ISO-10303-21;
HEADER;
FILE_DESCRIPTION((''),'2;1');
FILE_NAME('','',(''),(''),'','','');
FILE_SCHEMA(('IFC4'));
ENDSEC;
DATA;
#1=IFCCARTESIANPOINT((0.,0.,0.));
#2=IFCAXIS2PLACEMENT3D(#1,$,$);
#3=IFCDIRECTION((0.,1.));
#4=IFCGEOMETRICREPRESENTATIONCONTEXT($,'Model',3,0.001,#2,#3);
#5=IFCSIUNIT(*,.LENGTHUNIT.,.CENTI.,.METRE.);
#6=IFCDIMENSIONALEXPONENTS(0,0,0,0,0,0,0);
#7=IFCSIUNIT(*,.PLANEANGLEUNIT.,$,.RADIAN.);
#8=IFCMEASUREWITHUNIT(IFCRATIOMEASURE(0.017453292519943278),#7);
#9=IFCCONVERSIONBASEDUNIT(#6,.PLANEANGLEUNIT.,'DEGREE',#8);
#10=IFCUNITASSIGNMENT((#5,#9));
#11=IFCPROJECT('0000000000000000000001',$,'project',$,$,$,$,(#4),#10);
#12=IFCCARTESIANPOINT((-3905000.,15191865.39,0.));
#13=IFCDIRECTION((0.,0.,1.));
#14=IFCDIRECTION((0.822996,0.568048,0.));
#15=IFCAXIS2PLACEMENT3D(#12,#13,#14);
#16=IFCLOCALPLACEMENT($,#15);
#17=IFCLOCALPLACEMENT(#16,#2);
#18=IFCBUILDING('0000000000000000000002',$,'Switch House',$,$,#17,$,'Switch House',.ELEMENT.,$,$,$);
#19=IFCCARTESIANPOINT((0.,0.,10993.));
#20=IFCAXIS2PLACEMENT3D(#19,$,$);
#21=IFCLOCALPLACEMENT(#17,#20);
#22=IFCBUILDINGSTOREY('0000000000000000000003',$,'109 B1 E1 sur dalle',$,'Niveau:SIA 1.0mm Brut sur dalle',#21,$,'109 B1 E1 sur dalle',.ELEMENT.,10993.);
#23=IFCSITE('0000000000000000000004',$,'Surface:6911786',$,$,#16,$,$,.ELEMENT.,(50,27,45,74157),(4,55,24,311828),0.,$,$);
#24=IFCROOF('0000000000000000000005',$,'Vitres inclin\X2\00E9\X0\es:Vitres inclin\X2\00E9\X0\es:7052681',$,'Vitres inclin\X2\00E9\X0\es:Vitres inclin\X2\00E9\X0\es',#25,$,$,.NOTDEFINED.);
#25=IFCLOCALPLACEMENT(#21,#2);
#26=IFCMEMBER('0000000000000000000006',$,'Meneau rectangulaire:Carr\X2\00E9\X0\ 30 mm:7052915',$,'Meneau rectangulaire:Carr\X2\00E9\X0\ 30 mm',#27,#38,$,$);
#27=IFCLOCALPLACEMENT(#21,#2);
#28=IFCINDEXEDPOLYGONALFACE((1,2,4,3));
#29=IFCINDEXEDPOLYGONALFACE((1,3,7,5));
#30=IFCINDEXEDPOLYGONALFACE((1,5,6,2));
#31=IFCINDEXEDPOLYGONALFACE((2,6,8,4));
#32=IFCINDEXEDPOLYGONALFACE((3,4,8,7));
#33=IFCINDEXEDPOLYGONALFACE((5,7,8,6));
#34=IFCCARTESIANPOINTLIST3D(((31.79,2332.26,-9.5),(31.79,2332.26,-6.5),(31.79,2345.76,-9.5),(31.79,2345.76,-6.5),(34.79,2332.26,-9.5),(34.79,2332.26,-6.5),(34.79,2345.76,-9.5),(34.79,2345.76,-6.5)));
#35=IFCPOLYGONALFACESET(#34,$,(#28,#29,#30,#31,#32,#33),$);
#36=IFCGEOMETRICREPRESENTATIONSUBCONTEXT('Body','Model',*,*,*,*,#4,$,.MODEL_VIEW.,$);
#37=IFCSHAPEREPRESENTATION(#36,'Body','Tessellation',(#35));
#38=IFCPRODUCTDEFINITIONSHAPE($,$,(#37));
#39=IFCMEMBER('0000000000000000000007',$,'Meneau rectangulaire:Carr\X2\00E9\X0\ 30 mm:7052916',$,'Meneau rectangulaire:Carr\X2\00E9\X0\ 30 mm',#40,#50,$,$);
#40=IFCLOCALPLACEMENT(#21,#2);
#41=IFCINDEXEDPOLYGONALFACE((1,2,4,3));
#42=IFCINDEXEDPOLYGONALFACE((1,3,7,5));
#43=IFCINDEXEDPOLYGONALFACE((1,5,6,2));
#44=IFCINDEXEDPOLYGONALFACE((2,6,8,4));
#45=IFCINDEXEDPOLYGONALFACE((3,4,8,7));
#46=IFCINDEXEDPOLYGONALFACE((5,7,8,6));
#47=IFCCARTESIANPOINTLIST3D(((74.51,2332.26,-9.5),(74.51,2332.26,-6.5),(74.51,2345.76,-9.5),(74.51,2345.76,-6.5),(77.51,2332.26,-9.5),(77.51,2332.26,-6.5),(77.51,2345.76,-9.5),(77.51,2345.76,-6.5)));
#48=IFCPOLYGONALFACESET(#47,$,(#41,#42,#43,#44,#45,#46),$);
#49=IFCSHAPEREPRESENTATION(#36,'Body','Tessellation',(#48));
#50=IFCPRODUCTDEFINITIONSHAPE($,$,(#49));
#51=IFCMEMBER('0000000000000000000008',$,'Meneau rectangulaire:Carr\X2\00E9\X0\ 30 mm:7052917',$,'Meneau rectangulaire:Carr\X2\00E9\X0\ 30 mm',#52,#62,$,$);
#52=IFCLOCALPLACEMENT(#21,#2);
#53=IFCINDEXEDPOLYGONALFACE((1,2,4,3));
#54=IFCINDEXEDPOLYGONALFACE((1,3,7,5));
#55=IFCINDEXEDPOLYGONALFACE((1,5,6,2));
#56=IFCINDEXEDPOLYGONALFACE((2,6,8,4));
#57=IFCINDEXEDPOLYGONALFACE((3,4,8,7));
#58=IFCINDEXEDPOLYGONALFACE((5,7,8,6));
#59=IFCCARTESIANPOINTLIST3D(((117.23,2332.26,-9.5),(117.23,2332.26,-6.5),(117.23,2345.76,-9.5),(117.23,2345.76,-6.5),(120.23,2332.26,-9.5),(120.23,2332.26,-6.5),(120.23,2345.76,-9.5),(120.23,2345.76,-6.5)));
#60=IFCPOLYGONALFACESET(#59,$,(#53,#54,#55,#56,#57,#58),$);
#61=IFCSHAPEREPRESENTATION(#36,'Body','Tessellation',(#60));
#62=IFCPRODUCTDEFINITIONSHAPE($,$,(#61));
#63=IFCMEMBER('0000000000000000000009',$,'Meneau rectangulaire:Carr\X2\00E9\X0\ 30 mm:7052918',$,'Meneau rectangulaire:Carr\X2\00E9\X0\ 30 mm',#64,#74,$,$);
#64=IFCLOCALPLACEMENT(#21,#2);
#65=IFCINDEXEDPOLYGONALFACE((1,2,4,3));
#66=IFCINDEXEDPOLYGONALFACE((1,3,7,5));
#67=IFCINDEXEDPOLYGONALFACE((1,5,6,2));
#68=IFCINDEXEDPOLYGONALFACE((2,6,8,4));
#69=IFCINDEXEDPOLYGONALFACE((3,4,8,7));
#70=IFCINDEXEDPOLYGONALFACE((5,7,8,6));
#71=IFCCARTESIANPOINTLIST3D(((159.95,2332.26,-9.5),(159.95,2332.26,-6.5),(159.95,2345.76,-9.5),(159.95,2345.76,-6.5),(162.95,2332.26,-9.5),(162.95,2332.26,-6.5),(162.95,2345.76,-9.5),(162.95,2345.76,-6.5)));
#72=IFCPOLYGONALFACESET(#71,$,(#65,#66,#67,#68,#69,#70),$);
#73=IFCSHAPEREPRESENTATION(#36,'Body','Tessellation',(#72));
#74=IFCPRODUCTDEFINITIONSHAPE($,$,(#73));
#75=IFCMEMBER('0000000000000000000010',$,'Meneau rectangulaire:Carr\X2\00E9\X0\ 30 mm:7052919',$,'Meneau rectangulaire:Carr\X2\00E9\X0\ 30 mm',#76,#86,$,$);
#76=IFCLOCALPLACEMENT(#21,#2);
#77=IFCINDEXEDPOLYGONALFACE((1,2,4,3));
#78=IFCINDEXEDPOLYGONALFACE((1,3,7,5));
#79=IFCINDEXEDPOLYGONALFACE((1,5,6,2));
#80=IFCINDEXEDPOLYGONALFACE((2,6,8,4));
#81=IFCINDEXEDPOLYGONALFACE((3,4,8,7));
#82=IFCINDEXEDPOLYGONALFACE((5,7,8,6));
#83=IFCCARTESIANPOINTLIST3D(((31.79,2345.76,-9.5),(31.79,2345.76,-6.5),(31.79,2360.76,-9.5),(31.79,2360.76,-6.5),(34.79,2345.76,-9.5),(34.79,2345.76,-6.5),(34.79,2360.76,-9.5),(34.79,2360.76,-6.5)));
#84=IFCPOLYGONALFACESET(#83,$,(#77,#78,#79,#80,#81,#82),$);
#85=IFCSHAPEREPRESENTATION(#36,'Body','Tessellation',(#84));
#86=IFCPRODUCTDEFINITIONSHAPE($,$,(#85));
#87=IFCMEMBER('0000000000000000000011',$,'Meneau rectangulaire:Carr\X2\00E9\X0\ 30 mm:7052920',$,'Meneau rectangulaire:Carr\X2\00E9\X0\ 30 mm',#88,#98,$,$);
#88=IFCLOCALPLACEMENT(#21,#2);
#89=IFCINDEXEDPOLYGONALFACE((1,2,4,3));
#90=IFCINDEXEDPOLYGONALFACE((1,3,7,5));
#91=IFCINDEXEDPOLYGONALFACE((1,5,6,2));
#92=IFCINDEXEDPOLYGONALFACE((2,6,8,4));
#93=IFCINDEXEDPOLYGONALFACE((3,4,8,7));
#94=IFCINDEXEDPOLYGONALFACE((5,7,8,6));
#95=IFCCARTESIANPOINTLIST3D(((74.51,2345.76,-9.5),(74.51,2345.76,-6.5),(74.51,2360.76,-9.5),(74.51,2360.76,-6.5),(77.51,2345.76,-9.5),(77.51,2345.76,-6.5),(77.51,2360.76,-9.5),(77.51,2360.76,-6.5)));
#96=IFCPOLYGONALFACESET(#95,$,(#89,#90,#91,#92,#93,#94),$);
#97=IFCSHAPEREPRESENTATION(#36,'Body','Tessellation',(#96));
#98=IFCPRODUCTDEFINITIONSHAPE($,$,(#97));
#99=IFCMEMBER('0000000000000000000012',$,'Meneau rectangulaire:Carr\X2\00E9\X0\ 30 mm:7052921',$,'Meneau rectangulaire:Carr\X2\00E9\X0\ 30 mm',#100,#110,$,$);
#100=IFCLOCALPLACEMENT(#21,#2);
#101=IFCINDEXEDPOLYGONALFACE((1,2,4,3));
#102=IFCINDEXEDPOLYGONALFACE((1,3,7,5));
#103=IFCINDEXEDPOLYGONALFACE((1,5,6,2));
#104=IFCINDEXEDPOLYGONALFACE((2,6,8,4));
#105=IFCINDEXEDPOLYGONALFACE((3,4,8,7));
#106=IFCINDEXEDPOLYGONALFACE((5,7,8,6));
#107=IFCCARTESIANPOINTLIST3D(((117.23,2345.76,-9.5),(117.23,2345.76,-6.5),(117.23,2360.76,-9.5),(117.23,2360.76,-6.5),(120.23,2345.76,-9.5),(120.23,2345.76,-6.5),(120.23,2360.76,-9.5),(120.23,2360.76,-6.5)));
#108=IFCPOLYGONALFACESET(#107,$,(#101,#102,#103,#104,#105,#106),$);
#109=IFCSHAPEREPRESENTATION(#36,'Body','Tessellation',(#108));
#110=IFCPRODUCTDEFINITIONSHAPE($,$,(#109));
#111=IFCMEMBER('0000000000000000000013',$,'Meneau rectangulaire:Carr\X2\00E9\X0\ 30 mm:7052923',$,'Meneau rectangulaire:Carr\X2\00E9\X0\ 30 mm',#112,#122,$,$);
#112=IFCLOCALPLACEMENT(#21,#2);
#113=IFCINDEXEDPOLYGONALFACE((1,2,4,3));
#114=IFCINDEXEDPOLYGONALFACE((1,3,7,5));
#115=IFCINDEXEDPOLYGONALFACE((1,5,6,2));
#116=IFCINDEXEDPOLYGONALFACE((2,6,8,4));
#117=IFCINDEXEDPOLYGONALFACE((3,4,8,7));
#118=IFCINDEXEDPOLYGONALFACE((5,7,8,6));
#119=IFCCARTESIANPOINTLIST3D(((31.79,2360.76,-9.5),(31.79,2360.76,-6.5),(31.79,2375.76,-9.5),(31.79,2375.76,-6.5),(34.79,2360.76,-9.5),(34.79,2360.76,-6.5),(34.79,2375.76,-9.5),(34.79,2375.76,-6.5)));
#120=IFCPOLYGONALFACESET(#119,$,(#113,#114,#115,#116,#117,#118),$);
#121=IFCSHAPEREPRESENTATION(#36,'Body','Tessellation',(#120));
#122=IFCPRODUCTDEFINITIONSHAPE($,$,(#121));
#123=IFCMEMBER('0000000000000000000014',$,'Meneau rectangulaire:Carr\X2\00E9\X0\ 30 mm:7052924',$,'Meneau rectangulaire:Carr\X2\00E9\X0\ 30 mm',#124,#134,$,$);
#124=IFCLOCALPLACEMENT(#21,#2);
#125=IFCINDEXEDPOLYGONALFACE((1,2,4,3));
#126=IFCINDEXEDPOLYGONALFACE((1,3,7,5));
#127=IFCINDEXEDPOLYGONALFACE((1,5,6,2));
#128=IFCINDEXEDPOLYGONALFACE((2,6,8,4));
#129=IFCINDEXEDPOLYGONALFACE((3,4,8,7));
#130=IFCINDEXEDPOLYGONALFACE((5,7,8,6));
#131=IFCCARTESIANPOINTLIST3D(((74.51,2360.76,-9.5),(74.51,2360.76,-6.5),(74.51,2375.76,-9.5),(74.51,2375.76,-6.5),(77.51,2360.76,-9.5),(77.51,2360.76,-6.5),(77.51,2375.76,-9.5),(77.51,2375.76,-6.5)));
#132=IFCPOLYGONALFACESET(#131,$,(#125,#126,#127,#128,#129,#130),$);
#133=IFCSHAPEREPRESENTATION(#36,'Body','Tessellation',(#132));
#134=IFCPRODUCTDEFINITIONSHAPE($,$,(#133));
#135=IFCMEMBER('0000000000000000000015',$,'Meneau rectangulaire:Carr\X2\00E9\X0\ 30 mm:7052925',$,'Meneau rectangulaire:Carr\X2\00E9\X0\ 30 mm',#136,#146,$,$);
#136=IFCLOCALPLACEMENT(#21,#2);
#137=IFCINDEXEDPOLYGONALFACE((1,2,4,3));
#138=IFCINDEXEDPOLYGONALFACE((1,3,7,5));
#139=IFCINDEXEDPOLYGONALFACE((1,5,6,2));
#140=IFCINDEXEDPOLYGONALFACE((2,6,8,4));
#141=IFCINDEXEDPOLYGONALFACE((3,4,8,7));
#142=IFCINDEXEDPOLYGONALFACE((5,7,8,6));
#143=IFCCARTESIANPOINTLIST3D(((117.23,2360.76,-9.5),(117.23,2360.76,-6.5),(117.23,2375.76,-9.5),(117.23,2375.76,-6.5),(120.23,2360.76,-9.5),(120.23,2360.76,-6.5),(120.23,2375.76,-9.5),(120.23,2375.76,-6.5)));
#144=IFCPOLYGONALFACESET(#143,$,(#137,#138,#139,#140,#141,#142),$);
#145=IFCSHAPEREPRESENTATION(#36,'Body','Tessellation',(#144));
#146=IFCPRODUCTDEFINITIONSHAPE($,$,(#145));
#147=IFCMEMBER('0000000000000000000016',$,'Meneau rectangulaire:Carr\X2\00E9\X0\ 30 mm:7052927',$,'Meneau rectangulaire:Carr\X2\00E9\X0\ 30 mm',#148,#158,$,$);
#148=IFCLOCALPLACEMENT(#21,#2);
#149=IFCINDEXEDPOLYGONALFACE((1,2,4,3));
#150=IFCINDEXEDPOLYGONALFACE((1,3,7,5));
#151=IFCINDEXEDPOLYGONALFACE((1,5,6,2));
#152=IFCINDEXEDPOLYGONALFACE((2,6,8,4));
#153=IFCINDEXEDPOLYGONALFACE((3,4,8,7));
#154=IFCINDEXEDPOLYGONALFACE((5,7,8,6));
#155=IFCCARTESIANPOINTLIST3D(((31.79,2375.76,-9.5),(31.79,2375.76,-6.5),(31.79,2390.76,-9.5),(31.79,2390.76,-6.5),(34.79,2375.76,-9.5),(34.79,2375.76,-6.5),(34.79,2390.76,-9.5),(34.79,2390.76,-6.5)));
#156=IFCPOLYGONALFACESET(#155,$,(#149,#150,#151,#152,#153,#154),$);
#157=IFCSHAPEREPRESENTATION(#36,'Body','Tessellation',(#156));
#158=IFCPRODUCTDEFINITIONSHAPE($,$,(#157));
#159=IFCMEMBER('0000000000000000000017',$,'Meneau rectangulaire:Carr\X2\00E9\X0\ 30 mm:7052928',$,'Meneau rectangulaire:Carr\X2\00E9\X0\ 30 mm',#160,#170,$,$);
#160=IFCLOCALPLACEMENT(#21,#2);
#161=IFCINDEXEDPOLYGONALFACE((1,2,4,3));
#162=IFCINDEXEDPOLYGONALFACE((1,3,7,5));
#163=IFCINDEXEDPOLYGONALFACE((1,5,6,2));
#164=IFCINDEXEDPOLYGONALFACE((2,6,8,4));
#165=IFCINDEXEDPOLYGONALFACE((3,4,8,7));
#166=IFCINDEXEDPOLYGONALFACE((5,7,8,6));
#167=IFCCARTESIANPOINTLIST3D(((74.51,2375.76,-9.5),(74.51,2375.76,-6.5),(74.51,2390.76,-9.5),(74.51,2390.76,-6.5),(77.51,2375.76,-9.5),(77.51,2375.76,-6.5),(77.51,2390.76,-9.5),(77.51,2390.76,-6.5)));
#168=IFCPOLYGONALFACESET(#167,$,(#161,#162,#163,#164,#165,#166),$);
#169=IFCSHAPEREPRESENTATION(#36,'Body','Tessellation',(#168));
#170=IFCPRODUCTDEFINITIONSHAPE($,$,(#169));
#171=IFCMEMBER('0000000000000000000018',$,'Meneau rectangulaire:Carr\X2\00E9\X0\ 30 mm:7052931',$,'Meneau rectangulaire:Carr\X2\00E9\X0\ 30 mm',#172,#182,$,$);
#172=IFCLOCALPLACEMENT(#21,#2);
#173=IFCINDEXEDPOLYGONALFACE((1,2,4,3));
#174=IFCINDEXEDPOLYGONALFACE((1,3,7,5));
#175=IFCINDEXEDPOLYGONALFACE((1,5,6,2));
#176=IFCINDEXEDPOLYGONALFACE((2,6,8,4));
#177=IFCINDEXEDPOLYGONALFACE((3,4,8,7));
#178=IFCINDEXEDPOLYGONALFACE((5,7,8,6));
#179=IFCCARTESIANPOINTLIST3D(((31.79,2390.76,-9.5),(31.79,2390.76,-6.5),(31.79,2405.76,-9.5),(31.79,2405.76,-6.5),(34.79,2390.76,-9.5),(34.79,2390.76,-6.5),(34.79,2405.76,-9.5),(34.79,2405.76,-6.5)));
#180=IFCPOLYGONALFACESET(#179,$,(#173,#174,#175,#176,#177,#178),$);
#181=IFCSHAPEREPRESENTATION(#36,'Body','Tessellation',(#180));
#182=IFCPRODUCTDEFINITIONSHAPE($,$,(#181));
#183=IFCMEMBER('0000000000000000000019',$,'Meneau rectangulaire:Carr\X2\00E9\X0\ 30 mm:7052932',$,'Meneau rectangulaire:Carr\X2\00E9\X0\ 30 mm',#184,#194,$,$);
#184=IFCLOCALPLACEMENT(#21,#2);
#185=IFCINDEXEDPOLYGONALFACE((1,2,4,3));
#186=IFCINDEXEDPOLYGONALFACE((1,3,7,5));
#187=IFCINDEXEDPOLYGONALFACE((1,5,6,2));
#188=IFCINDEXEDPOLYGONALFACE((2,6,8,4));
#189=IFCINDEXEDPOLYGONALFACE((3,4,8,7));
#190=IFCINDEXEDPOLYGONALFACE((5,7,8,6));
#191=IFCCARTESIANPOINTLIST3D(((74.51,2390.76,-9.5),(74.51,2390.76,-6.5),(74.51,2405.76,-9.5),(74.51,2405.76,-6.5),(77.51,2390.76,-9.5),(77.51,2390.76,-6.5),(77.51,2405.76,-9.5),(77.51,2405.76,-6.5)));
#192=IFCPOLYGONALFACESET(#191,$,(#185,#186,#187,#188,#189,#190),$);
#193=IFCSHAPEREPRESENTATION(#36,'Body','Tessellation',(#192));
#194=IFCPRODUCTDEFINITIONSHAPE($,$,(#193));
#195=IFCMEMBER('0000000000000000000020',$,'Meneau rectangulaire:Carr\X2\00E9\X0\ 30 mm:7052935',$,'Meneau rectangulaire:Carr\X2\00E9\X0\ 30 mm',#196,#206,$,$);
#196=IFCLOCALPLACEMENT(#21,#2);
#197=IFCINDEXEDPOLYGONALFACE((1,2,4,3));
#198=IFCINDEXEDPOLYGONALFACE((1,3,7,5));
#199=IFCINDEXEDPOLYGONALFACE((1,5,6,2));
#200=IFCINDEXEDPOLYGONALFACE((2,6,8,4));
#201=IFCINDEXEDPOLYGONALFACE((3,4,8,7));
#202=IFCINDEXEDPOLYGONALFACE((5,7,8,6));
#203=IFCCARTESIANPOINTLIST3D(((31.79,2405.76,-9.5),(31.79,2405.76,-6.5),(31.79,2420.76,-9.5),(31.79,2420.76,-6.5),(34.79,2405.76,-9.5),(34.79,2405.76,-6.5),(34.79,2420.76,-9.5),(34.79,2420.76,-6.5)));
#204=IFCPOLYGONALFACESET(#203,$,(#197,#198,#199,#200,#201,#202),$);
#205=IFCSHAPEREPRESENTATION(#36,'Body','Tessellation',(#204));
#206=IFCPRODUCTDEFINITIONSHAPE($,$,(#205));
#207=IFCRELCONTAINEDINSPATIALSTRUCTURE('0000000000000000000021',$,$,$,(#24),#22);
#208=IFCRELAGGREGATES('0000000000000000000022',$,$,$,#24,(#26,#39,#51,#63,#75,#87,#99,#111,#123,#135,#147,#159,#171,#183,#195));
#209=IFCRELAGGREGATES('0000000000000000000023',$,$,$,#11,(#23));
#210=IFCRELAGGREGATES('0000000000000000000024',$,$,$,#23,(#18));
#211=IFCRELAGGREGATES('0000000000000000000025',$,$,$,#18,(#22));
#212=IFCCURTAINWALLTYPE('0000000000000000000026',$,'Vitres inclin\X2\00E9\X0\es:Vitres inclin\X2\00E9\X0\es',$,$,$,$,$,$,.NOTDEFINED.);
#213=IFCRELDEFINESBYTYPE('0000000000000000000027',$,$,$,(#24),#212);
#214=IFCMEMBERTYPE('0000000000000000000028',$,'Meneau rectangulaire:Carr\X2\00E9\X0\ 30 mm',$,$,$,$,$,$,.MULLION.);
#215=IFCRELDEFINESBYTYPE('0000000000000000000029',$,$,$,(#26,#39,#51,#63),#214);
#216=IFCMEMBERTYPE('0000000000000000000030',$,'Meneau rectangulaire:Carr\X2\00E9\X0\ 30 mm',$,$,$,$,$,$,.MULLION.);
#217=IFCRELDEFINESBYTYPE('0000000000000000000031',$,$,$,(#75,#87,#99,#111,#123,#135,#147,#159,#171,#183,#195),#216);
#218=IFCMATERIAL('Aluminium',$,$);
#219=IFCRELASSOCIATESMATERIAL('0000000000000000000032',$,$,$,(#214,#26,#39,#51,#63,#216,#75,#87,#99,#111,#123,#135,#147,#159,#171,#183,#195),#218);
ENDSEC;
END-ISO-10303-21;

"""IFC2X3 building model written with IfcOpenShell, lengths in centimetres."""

from ifc_helpers import new_model, entity, si_unit, converted_unit, direction, frame, origin, origin_2d_with_axis, place, context, subcontext, project, spatial, rectangle, extrude, source, transform, mapped, material, type_object, type_shapes, element, aggregate, save


model = new_model("IFC2X3")

# Units and contexts
model_context = context("Model", 3, precision=0.001, world=origin(), true_north=direction((0.0, 1.0)))
body_context = subcontext(model_context, "Body", "Model", "MODEL_VIEW")
ifc_project = project(units=[si_unit("LENGTHUNIT", "METRE", prefix="CENTI"), converted_unit("PLANEANGLEUNIT", "DEGREE", entity("IfcRatioMeasure", 0.017453292519943278), si_unit("PLANEANGLEUNIT", "RADIAN"), dimensions=[0, 0, 0, 0, 0, 0, 0])], contexts=[model_context])

# Site, building, storey
site_placement = place(None, frame((-3905000.0, 15191865.39, 0.0), z_axis=(0.0, 0.0, 1.0), x_axis=(0.822996, 0.568048, 0.0)))
site = spatial("IfcSite", under=ifc_project, at=site_placement, Name="Surface:6911786", CompositionType="ELEMENT", RefLatitude=(50, 27, 45, 74157), RefLongitude=(4, 55, 24, 311828), RefElevation=0.0)
building_placement = place(site_placement, origin())
building = spatial("IfcBuilding", under=site, at=building_placement, Name="Switch House", LongName="Switch House", CompositionType="ELEMENT")
storey_placement = place(building_placement, frame((0.0, 0.0, 10993.0)))
storey = spatial("IfcBuildingStorey", under=building, at=storey_placement, Name="109 B1 E1 sur dalle", ObjectType="Niveau:SIA 1.0mm Brut sur dalle", LongName="109 B1 E1 sur dalle", CompositionType="ELEMENT", Elevation=10993.0)

# Roof, members
curtain_wall_type = type_object("IfcCurtainWallType", Name="Vitres inclinées:Vitres inclinées", PredefinedType="NOTDEFINED")
roof_placement = place(storey_placement, frame((0.0, 0.0, -10993.0)))
roof = element("IfcRoof", 1, at=roof_placement, inside=storey, type_object=curtain_wall_type, Name="Vitres inclinées:Vitres inclinées:7052681", ObjectType="Vitres inclinées:Vitres inclinées", ShapeType="NOTDEFINED")
ifc_material = material(Name="Aluminium")
member_type_1 = type_object("IfcMemberType", Name="Meneau rectangulaire:Carré 30 mm", PredefinedType="MULLION", material=ifc_material)
shared_shape_1 = source(origin(), body_context, "Body", "SweptSolid", [
    extrude(rectangle(XDim=3.0, YDim=3.0, at=origin_2d_with_axis()), frame((0.0, 0.0, -13.5), z_axis=(0.0, 0.0, 1.0), x_axis=(0.0, -1.0, 0.0)), (0.0, 0.0, 1.0), 13.5),
])
type_shapes(member_type_1, [shared_shape_1])
member_1_placement = place(roof_placement, frame((33.29, 2345.76, 10985.0), z_axis=(0.0, 1.0, 0.0), x_axis=(1.0, 0.0, 0.0)))
member_1 = element("IfcMember", 2, at=member_1_placement, type_object=member_type_1, material=ifc_material, Name="Meneau rectangulaire:Carré 30 mm:7052915", ObjectType="Meneau rectangulaire:Carré 30 mm", context=body_context, shape_type="MappedRepresentation", body=[
    mapped(shared_shape_1, transform((0.0, 0.0, 0.0), scale=1.0)),
])
member_2_placement = place(roof_placement, frame((76.01, 2345.76, 10985.0), z_axis=(0.0, 1.0, 0.0), x_axis=(1.0, 0.0, 0.0)))
member_2 = element("IfcMember", 3, at=member_2_placement, type_object=member_type_1, material=ifc_material, Name="Meneau rectangulaire:Carré 30 mm:7052916", ObjectType="Meneau rectangulaire:Carré 30 mm", context=body_context, shape_type="MappedRepresentation", body=[
    mapped(shared_shape_1, transform((0.0, 0.0, 0.0), scale=1.0)),
])
member_3_placement = place(roof_placement, frame((118.73, 2345.76, 10985.0), z_axis=(0.0, 1.0, 0.0), x_axis=(1.0, 0.0, 0.0)))
member_3 = element("IfcMember", 4, at=member_3_placement, type_object=member_type_1, material=ifc_material, Name="Meneau rectangulaire:Carré 30 mm:7052917", ObjectType="Meneau rectangulaire:Carré 30 mm", context=body_context, shape_type="MappedRepresentation", body=[
    mapped(shared_shape_1, transform((0.0, 0.0, 0.0), scale=1.0)),
])
member_4_placement = place(roof_placement, frame((161.45, 2345.76, 10985.0), z_axis=(0.0, 1.0, 0.0), x_axis=(1.0, 0.0, 0.0)))
member_4 = element("IfcMember", 5, at=member_4_placement, type_object=member_type_1, material=ifc_material, Name="Meneau rectangulaire:Carré 30 mm:7052918", ObjectType="Meneau rectangulaire:Carré 30 mm", context=body_context, shape_type="MappedRepresentation", body=[
    mapped(shared_shape_1, transform((0.0, 0.0, 0.0), scale=1.0)),
])
member_type_2 = type_object("IfcMemberType", Name="Meneau rectangulaire:Carré 30 mm", PredefinedType="MULLION", material=ifc_material)
shared_shape_2 = source(origin(), body_context, "Body", "SweptSolid", [
    extrude(rectangle(XDim=3.0, YDim=3.0, at=origin_2d_with_axis()), frame((0.0, 0.0, -15.0), z_axis=(0.0, 0.0, 1.0), x_axis=(0.0, -1.0, 0.0)), (0.0, 0.0, 1.0), 15.0),
])
type_shapes(member_type_2, [shared_shape_2])
member_5_placement = place(roof_placement, frame((33.29, 2360.76, 10985.0), z_axis=(0.0, 1.0, 0.0), x_axis=(1.0, 0.0, 0.0)))
member_5 = element("IfcMember", 6, at=member_5_placement, type_object=member_type_2, material=ifc_material, Name="Meneau rectangulaire:Carré 30 mm:7052919", ObjectType="Meneau rectangulaire:Carré 30 mm", context=body_context, shape_type="MappedRepresentation", body=[
    mapped(shared_shape_2, transform((0.0, 0.0, 0.0), scale=1.0)),
])
member_6_placement = place(roof_placement, frame((76.01, 2360.76, 10985.0), z_axis=(0.0, 1.0, 0.0), x_axis=(1.0, 0.0, 0.0)))
member_6 = element("IfcMember", 7, at=member_6_placement, type_object=member_type_2, material=ifc_material, Name="Meneau rectangulaire:Carré 30 mm:7052920", ObjectType="Meneau rectangulaire:Carré 30 mm", context=body_context, shape_type="MappedRepresentation", body=[
    mapped(shared_shape_2, transform((0.0, 0.0, 0.0), scale=1.0)),
])
member_7_placement = place(roof_placement, frame((118.73, 2360.76, 10985.0), z_axis=(0.0, 1.0, 0.0), x_axis=(1.0, 0.0, 0.0)))
member_7 = element("IfcMember", 8, at=member_7_placement, type_object=member_type_2, material=ifc_material, Name="Meneau rectangulaire:Carré 30 mm:7052921", ObjectType="Meneau rectangulaire:Carré 30 mm", context=body_context, shape_type="MappedRepresentation", body=[
    mapped(shared_shape_2, transform((0.0, 0.0, 0.0), scale=1.0)),
])
member_8_placement = place(roof_placement, frame((33.29, 2375.76, 10985.0), z_axis=(0.0, 1.0, 0.0), x_axis=(1.0, 0.0, 0.0)))
member_8 = element("IfcMember", 9, at=member_8_placement, type_object=member_type_2, material=ifc_material, Name="Meneau rectangulaire:Carré 30 mm:7052923", ObjectType="Meneau rectangulaire:Carré 30 mm", context=body_context, shape_type="MappedRepresentation", body=[
    mapped(shared_shape_2, transform((0.0, 0.0, 0.0), scale=1.0)),
])
member_9_placement = place(roof_placement, frame((76.01, 2375.76, 10985.0), z_axis=(0.0, 1.0, 0.0), x_axis=(1.0, 0.0, 0.0)))
member_9 = element("IfcMember", 10, at=member_9_placement, type_object=member_type_2, material=ifc_material, Name="Meneau rectangulaire:Carré 30 mm:7052924", ObjectType="Meneau rectangulaire:Carré 30 mm", context=body_context, shape_type="MappedRepresentation", body=[
    mapped(shared_shape_2, transform((0.0, 0.0, 0.0), scale=1.0)),
])
member_10_placement = place(roof_placement, frame((118.73, 2375.76, 10985.0), z_axis=(0.0, 1.0, 0.0), x_axis=(1.0, 0.0, 0.0)))
member_10 = element("IfcMember", 11, at=member_10_placement, type_object=member_type_2, material=ifc_material, Name="Meneau rectangulaire:Carré 30 mm:7052925", ObjectType="Meneau rectangulaire:Carré 30 mm", context=body_context, shape_type="MappedRepresentation", body=[
    mapped(shared_shape_2, transform((0.0, 0.0, 0.0), scale=1.0)),
])
member_11_placement = place(roof_placement, frame((33.29, 2390.76, 10985.0), z_axis=(0.0, 1.0, 0.0), x_axis=(1.0, 0.0, 0.0)))
member_11 = element("IfcMember", 12, at=member_11_placement, type_object=member_type_2, material=ifc_material, Name="Meneau rectangulaire:Carré 30 mm:7052927", ObjectType="Meneau rectangulaire:Carré 30 mm", context=body_context, shape_type="MappedRepresentation", body=[
    mapped(shared_shape_2, transform((0.0, 0.0, 0.0), scale=1.0)),
])
member_12_placement = place(roof_placement, frame((76.01, 2390.76, 10985.0), z_axis=(0.0, 1.0, 0.0), x_axis=(1.0, 0.0, 0.0)))
member_12 = element("IfcMember", 13, at=member_12_placement, type_object=member_type_2, material=ifc_material, Name="Meneau rectangulaire:Carré 30 mm:7052928", ObjectType="Meneau rectangulaire:Carré 30 mm", context=body_context, shape_type="MappedRepresentation", body=[
    mapped(shared_shape_2, transform((0.0, 0.0, 0.0), scale=1.0)),
])
member_13_placement = place(roof_placement, frame((33.29, 2405.76, 10985.0), z_axis=(0.0, 1.0, 0.0), x_axis=(1.0, 0.0, 0.0)))
member_13 = element("IfcMember", 14, at=member_13_placement, type_object=member_type_2, material=ifc_material, Name="Meneau rectangulaire:Carré 30 mm:7052931", ObjectType="Meneau rectangulaire:Carré 30 mm", context=body_context, shape_type="MappedRepresentation", body=[
    mapped(shared_shape_2, transform((0.0, 0.0, 0.0), scale=1.0)),
])
member_14_placement = place(roof_placement, frame((76.01, 2405.76, 10985.0), z_axis=(0.0, 1.0, 0.0), x_axis=(1.0, 0.0, 0.0)))
member_14 = element("IfcMember", 15, at=member_14_placement, type_object=member_type_2, material=ifc_material, Name="Meneau rectangulaire:Carré 30 mm:7052932", ObjectType="Meneau rectangulaire:Carré 30 mm", context=body_context, shape_type="MappedRepresentation", body=[
    mapped(shared_shape_2, transform((0.0, 0.0, 0.0), scale=1.0)),
])
member_15_placement = place(roof_placement, frame((33.29, 2420.76, 10985.0), z_axis=(0.0, 1.0, 0.0), x_axis=(1.0, 0.0, 0.0)))
member_15 = element("IfcMember", 16, at=member_15_placement, type_object=member_type_2, material=ifc_material, Name="Meneau rectangulaire:Carré 30 mm:7052935", ObjectType="Meneau rectangulaire:Carré 30 mm", context=body_context, shape_type="MappedRepresentation", body=[
    mapped(shared_shape_2, transform((0.0, 0.0, 0.0), scale=1.0)),
])
aggregate(roof, [member_1, member_2, member_3, member_4, member_5, member_6, member_7, member_8, member_9, member_10, member_11, member_12, member_13, member_14, member_15])

save(model, "model.ifc")
